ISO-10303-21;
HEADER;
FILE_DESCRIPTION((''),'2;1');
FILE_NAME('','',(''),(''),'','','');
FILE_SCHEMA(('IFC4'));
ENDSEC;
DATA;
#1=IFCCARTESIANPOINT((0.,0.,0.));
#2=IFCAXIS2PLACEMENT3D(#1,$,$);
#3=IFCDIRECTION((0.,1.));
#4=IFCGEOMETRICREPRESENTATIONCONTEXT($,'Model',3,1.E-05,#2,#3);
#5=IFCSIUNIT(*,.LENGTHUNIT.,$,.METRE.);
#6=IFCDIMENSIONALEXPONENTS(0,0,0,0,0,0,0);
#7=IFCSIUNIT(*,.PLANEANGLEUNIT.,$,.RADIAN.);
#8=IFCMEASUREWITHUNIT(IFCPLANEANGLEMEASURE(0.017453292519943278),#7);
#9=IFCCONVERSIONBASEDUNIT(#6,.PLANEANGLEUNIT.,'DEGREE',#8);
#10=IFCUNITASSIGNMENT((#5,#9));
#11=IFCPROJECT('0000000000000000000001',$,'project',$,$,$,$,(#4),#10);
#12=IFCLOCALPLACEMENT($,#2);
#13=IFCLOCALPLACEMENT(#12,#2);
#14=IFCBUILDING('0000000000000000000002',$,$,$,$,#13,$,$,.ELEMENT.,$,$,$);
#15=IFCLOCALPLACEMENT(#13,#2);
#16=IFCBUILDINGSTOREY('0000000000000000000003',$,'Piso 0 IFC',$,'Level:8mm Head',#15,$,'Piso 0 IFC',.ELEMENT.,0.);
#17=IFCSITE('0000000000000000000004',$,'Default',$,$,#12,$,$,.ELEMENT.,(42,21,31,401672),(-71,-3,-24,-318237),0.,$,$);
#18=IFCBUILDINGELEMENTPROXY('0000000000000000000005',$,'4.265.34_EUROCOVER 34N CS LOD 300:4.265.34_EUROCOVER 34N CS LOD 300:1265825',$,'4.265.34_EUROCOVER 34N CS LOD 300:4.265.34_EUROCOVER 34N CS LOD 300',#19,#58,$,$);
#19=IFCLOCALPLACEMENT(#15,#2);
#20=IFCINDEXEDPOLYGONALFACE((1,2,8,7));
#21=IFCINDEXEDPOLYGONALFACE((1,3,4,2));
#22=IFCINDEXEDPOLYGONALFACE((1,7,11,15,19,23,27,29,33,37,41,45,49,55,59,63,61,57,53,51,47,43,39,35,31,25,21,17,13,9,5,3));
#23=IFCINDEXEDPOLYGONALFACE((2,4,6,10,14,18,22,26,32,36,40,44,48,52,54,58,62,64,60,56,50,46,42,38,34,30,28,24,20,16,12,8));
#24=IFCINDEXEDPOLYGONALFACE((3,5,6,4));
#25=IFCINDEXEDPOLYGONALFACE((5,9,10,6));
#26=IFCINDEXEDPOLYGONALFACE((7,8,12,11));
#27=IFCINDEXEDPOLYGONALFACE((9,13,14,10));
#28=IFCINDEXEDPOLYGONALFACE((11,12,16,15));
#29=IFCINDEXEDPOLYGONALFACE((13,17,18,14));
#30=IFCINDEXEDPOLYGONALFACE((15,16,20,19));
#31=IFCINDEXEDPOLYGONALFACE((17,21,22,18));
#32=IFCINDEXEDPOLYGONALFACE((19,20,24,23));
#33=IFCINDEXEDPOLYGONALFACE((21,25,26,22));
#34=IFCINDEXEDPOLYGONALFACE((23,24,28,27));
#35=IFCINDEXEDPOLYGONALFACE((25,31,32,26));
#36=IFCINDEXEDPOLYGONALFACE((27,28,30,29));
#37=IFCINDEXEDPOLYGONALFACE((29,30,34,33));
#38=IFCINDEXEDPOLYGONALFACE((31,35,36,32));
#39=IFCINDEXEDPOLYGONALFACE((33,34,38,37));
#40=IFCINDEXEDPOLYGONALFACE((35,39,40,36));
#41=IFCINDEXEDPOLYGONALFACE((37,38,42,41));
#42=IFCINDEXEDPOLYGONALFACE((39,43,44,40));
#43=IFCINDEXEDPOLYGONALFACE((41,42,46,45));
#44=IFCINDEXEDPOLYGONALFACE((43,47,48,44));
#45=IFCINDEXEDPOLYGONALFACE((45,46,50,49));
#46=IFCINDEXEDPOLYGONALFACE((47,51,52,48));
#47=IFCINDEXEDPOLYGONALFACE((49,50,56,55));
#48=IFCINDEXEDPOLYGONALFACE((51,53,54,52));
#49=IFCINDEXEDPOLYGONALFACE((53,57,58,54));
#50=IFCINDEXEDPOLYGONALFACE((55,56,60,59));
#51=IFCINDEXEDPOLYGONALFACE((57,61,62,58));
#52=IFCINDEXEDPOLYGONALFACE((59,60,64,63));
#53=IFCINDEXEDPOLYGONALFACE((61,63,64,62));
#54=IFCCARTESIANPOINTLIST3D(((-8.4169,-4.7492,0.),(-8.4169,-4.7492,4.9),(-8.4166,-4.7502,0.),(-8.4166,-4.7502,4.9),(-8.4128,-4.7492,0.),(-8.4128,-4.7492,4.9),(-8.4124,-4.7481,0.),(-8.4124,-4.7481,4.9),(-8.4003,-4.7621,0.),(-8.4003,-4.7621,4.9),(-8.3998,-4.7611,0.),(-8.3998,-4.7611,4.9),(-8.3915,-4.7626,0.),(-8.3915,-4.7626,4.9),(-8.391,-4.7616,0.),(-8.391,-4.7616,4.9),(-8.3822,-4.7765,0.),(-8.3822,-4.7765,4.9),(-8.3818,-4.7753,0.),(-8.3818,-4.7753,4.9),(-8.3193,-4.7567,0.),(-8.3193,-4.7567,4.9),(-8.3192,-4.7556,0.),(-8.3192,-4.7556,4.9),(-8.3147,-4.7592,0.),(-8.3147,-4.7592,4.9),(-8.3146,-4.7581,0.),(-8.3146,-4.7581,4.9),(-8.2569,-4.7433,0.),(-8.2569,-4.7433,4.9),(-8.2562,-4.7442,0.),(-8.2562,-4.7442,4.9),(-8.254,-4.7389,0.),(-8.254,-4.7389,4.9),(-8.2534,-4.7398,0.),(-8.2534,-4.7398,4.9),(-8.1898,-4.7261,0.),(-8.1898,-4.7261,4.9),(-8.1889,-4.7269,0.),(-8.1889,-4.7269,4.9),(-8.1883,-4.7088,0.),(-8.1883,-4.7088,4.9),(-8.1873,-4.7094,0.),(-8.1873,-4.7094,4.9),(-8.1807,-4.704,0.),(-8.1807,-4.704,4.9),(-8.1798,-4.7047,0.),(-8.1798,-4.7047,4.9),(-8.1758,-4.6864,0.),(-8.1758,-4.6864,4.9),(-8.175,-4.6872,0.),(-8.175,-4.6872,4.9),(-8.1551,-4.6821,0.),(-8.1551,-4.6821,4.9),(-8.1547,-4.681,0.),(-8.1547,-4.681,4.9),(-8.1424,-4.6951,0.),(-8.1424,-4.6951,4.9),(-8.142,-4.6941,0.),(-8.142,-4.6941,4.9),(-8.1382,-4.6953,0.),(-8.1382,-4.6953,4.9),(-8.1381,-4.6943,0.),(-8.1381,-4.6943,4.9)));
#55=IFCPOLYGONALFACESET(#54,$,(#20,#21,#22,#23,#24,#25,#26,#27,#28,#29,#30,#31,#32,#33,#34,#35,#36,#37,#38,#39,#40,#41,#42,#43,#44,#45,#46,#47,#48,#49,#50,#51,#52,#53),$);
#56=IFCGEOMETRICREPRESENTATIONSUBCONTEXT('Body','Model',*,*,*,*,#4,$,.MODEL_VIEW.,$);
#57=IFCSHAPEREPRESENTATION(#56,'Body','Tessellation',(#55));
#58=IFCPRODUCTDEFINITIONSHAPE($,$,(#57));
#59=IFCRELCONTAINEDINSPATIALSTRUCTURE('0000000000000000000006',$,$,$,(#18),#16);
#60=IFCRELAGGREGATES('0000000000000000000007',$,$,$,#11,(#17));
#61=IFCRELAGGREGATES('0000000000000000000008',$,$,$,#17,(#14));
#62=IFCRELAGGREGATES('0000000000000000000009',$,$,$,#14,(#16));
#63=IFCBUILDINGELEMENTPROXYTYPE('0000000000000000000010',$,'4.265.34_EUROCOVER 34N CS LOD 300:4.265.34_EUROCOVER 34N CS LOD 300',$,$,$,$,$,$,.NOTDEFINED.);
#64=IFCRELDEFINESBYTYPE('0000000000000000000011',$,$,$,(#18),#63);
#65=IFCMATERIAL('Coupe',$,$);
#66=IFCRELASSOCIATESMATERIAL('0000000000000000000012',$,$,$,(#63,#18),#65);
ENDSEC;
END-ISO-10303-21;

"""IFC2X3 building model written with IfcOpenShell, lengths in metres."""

from ifc_helpers import new_model, entity, si_unit, converted_unit, direction, frame, origin, place, context, subcontext, project, spatial, polyline, outline, extrude, source, transform, mapped, material, type_object, type_shapes, element, save


model = new_model("IFC2X3")

# Units and contexts
model_context = context("Model", 3, precision=1e-05, world=origin(), true_north=direction((0.0, 1.0)))
body_context = subcontext(model_context, "Body", "Model", "MODEL_VIEW")
ifc_project = project(units=[si_unit("LENGTHUNIT", "METRE"), converted_unit("PLANEANGLEUNIT", "DEGREE", entity("IfcPlaneAngleMeasure", 0.017453292519943278), si_unit("PLANEANGLEUNIT", "RADIAN"), dimensions=[0, 0, 0, 0, 0, 0, 0])], contexts=[model_context])

# Site, building, storey
site_placement = place(None, origin())
site = spatial("IfcSite", under=ifc_project, at=site_placement, Name="Default", CompositionType="ELEMENT", RefLatitude=(42, 21, 31, 401672), RefLongitude=(-71, -3, -24, -318237), RefElevation=0.0)
building_placement = place(site_placement, origin())
building = spatial("IfcBuilding", under=site, at=building_placement, CompositionType="ELEMENT")
storey_placement = place(building_placement, origin())
storey = spatial("IfcBuildingStorey", under=building, at=storey_placement, Name="Piso 0 IFC", ObjectType="Level:8mm Head", LongName="Piso 0 IFC", CompositionType="ELEMENT", Elevation=0.0)

# Building element proxy
ifc_material_1 = material(Name="Coupe")
building_element_proxy_type = type_object("IfcBuildingElementProxyType", Name="4.265.34_EUROCOVER 34N CS LOD 300:4.265.34_EUROCOVER 34N CS LOD 300", PredefinedType="NOTDEFINED", material=ifc_material_1)
shared_shape = source(origin(), body_context, "Body", "SweptSolid", [
    extrude(outline(polyline([(0.0449, 0.1162), (0.063, 0.1162), (0.0661, 0.1191), (0.0654, 0.1198), (0.0626, 0.1172), (0.0443, 0.1172), (0.0335, 0.0983), (0.0428, 0.0826), (0.0409, 0.0738), (0.0522, 0.0606), (0.0167, 0.0056), (0.0179, 0.0005), (-0.0117, -0.0512), (-0.0167, -0.0528), (-0.0462, -0.1114), (-0.0624, -0.1084), (-0.069, -0.1145), (-0.0871, -0.1145), (-0.0893, -0.1184), (-0.0885, -0.1189), (-0.0865, -0.1155), (-0.0686, -0.1155), (-0.0621, -0.1095), (-0.0456, -0.1125), (-0.016, -0.0536), (-0.0111, -0.0521), (0.0189, 0.0004), (0.0177, 0.0054), (0.0535, 0.0607), (0.0419, 0.074), (0.0438, 0.0827), (0.0347, 0.0983), (0.0449, 0.1162)])), frame((-0.0171, -0.0163, 0.0), z_axis=(0.0, 0.0, 1.0), x_axis=(-0.496574, 0.867994, 0.0)), (0.0, 0.0, 1.0), 4.9),
])
type_shapes(building_element_proxy_type, [shared_shape])
for number, where, z_axis, x_axis, name in (
    (1, (-8.2823, -4.7509, 0.0), (0.0, 0.0, 1.0), (-0.968666, -0.248367, 0.0), "4.265.34_EUROCOVER 34N CS LOD 300:4.265.34_EUROCOVER 34N CS LOD 300:1265825"),
):
    element("IfcBuildingElementProxy", number, at=place(storey_placement, frame(where, z_axis=z_axis, x_axis=x_axis)), inside=storey, type_object=building_element_proxy_type, material=ifc_material_1, Name=name, ObjectType="4.265.34_EUROCOVER 34N CS LOD 300:4.265.34_EUROCOVER 34N CS LOD 300", context=body_context, shape_type="MappedRepresentation", body=[
        mapped(shared_shape, transform((0.0, 0.0, 0.0), scale=1.0)),
    ])

save(model, "model.ifc")
